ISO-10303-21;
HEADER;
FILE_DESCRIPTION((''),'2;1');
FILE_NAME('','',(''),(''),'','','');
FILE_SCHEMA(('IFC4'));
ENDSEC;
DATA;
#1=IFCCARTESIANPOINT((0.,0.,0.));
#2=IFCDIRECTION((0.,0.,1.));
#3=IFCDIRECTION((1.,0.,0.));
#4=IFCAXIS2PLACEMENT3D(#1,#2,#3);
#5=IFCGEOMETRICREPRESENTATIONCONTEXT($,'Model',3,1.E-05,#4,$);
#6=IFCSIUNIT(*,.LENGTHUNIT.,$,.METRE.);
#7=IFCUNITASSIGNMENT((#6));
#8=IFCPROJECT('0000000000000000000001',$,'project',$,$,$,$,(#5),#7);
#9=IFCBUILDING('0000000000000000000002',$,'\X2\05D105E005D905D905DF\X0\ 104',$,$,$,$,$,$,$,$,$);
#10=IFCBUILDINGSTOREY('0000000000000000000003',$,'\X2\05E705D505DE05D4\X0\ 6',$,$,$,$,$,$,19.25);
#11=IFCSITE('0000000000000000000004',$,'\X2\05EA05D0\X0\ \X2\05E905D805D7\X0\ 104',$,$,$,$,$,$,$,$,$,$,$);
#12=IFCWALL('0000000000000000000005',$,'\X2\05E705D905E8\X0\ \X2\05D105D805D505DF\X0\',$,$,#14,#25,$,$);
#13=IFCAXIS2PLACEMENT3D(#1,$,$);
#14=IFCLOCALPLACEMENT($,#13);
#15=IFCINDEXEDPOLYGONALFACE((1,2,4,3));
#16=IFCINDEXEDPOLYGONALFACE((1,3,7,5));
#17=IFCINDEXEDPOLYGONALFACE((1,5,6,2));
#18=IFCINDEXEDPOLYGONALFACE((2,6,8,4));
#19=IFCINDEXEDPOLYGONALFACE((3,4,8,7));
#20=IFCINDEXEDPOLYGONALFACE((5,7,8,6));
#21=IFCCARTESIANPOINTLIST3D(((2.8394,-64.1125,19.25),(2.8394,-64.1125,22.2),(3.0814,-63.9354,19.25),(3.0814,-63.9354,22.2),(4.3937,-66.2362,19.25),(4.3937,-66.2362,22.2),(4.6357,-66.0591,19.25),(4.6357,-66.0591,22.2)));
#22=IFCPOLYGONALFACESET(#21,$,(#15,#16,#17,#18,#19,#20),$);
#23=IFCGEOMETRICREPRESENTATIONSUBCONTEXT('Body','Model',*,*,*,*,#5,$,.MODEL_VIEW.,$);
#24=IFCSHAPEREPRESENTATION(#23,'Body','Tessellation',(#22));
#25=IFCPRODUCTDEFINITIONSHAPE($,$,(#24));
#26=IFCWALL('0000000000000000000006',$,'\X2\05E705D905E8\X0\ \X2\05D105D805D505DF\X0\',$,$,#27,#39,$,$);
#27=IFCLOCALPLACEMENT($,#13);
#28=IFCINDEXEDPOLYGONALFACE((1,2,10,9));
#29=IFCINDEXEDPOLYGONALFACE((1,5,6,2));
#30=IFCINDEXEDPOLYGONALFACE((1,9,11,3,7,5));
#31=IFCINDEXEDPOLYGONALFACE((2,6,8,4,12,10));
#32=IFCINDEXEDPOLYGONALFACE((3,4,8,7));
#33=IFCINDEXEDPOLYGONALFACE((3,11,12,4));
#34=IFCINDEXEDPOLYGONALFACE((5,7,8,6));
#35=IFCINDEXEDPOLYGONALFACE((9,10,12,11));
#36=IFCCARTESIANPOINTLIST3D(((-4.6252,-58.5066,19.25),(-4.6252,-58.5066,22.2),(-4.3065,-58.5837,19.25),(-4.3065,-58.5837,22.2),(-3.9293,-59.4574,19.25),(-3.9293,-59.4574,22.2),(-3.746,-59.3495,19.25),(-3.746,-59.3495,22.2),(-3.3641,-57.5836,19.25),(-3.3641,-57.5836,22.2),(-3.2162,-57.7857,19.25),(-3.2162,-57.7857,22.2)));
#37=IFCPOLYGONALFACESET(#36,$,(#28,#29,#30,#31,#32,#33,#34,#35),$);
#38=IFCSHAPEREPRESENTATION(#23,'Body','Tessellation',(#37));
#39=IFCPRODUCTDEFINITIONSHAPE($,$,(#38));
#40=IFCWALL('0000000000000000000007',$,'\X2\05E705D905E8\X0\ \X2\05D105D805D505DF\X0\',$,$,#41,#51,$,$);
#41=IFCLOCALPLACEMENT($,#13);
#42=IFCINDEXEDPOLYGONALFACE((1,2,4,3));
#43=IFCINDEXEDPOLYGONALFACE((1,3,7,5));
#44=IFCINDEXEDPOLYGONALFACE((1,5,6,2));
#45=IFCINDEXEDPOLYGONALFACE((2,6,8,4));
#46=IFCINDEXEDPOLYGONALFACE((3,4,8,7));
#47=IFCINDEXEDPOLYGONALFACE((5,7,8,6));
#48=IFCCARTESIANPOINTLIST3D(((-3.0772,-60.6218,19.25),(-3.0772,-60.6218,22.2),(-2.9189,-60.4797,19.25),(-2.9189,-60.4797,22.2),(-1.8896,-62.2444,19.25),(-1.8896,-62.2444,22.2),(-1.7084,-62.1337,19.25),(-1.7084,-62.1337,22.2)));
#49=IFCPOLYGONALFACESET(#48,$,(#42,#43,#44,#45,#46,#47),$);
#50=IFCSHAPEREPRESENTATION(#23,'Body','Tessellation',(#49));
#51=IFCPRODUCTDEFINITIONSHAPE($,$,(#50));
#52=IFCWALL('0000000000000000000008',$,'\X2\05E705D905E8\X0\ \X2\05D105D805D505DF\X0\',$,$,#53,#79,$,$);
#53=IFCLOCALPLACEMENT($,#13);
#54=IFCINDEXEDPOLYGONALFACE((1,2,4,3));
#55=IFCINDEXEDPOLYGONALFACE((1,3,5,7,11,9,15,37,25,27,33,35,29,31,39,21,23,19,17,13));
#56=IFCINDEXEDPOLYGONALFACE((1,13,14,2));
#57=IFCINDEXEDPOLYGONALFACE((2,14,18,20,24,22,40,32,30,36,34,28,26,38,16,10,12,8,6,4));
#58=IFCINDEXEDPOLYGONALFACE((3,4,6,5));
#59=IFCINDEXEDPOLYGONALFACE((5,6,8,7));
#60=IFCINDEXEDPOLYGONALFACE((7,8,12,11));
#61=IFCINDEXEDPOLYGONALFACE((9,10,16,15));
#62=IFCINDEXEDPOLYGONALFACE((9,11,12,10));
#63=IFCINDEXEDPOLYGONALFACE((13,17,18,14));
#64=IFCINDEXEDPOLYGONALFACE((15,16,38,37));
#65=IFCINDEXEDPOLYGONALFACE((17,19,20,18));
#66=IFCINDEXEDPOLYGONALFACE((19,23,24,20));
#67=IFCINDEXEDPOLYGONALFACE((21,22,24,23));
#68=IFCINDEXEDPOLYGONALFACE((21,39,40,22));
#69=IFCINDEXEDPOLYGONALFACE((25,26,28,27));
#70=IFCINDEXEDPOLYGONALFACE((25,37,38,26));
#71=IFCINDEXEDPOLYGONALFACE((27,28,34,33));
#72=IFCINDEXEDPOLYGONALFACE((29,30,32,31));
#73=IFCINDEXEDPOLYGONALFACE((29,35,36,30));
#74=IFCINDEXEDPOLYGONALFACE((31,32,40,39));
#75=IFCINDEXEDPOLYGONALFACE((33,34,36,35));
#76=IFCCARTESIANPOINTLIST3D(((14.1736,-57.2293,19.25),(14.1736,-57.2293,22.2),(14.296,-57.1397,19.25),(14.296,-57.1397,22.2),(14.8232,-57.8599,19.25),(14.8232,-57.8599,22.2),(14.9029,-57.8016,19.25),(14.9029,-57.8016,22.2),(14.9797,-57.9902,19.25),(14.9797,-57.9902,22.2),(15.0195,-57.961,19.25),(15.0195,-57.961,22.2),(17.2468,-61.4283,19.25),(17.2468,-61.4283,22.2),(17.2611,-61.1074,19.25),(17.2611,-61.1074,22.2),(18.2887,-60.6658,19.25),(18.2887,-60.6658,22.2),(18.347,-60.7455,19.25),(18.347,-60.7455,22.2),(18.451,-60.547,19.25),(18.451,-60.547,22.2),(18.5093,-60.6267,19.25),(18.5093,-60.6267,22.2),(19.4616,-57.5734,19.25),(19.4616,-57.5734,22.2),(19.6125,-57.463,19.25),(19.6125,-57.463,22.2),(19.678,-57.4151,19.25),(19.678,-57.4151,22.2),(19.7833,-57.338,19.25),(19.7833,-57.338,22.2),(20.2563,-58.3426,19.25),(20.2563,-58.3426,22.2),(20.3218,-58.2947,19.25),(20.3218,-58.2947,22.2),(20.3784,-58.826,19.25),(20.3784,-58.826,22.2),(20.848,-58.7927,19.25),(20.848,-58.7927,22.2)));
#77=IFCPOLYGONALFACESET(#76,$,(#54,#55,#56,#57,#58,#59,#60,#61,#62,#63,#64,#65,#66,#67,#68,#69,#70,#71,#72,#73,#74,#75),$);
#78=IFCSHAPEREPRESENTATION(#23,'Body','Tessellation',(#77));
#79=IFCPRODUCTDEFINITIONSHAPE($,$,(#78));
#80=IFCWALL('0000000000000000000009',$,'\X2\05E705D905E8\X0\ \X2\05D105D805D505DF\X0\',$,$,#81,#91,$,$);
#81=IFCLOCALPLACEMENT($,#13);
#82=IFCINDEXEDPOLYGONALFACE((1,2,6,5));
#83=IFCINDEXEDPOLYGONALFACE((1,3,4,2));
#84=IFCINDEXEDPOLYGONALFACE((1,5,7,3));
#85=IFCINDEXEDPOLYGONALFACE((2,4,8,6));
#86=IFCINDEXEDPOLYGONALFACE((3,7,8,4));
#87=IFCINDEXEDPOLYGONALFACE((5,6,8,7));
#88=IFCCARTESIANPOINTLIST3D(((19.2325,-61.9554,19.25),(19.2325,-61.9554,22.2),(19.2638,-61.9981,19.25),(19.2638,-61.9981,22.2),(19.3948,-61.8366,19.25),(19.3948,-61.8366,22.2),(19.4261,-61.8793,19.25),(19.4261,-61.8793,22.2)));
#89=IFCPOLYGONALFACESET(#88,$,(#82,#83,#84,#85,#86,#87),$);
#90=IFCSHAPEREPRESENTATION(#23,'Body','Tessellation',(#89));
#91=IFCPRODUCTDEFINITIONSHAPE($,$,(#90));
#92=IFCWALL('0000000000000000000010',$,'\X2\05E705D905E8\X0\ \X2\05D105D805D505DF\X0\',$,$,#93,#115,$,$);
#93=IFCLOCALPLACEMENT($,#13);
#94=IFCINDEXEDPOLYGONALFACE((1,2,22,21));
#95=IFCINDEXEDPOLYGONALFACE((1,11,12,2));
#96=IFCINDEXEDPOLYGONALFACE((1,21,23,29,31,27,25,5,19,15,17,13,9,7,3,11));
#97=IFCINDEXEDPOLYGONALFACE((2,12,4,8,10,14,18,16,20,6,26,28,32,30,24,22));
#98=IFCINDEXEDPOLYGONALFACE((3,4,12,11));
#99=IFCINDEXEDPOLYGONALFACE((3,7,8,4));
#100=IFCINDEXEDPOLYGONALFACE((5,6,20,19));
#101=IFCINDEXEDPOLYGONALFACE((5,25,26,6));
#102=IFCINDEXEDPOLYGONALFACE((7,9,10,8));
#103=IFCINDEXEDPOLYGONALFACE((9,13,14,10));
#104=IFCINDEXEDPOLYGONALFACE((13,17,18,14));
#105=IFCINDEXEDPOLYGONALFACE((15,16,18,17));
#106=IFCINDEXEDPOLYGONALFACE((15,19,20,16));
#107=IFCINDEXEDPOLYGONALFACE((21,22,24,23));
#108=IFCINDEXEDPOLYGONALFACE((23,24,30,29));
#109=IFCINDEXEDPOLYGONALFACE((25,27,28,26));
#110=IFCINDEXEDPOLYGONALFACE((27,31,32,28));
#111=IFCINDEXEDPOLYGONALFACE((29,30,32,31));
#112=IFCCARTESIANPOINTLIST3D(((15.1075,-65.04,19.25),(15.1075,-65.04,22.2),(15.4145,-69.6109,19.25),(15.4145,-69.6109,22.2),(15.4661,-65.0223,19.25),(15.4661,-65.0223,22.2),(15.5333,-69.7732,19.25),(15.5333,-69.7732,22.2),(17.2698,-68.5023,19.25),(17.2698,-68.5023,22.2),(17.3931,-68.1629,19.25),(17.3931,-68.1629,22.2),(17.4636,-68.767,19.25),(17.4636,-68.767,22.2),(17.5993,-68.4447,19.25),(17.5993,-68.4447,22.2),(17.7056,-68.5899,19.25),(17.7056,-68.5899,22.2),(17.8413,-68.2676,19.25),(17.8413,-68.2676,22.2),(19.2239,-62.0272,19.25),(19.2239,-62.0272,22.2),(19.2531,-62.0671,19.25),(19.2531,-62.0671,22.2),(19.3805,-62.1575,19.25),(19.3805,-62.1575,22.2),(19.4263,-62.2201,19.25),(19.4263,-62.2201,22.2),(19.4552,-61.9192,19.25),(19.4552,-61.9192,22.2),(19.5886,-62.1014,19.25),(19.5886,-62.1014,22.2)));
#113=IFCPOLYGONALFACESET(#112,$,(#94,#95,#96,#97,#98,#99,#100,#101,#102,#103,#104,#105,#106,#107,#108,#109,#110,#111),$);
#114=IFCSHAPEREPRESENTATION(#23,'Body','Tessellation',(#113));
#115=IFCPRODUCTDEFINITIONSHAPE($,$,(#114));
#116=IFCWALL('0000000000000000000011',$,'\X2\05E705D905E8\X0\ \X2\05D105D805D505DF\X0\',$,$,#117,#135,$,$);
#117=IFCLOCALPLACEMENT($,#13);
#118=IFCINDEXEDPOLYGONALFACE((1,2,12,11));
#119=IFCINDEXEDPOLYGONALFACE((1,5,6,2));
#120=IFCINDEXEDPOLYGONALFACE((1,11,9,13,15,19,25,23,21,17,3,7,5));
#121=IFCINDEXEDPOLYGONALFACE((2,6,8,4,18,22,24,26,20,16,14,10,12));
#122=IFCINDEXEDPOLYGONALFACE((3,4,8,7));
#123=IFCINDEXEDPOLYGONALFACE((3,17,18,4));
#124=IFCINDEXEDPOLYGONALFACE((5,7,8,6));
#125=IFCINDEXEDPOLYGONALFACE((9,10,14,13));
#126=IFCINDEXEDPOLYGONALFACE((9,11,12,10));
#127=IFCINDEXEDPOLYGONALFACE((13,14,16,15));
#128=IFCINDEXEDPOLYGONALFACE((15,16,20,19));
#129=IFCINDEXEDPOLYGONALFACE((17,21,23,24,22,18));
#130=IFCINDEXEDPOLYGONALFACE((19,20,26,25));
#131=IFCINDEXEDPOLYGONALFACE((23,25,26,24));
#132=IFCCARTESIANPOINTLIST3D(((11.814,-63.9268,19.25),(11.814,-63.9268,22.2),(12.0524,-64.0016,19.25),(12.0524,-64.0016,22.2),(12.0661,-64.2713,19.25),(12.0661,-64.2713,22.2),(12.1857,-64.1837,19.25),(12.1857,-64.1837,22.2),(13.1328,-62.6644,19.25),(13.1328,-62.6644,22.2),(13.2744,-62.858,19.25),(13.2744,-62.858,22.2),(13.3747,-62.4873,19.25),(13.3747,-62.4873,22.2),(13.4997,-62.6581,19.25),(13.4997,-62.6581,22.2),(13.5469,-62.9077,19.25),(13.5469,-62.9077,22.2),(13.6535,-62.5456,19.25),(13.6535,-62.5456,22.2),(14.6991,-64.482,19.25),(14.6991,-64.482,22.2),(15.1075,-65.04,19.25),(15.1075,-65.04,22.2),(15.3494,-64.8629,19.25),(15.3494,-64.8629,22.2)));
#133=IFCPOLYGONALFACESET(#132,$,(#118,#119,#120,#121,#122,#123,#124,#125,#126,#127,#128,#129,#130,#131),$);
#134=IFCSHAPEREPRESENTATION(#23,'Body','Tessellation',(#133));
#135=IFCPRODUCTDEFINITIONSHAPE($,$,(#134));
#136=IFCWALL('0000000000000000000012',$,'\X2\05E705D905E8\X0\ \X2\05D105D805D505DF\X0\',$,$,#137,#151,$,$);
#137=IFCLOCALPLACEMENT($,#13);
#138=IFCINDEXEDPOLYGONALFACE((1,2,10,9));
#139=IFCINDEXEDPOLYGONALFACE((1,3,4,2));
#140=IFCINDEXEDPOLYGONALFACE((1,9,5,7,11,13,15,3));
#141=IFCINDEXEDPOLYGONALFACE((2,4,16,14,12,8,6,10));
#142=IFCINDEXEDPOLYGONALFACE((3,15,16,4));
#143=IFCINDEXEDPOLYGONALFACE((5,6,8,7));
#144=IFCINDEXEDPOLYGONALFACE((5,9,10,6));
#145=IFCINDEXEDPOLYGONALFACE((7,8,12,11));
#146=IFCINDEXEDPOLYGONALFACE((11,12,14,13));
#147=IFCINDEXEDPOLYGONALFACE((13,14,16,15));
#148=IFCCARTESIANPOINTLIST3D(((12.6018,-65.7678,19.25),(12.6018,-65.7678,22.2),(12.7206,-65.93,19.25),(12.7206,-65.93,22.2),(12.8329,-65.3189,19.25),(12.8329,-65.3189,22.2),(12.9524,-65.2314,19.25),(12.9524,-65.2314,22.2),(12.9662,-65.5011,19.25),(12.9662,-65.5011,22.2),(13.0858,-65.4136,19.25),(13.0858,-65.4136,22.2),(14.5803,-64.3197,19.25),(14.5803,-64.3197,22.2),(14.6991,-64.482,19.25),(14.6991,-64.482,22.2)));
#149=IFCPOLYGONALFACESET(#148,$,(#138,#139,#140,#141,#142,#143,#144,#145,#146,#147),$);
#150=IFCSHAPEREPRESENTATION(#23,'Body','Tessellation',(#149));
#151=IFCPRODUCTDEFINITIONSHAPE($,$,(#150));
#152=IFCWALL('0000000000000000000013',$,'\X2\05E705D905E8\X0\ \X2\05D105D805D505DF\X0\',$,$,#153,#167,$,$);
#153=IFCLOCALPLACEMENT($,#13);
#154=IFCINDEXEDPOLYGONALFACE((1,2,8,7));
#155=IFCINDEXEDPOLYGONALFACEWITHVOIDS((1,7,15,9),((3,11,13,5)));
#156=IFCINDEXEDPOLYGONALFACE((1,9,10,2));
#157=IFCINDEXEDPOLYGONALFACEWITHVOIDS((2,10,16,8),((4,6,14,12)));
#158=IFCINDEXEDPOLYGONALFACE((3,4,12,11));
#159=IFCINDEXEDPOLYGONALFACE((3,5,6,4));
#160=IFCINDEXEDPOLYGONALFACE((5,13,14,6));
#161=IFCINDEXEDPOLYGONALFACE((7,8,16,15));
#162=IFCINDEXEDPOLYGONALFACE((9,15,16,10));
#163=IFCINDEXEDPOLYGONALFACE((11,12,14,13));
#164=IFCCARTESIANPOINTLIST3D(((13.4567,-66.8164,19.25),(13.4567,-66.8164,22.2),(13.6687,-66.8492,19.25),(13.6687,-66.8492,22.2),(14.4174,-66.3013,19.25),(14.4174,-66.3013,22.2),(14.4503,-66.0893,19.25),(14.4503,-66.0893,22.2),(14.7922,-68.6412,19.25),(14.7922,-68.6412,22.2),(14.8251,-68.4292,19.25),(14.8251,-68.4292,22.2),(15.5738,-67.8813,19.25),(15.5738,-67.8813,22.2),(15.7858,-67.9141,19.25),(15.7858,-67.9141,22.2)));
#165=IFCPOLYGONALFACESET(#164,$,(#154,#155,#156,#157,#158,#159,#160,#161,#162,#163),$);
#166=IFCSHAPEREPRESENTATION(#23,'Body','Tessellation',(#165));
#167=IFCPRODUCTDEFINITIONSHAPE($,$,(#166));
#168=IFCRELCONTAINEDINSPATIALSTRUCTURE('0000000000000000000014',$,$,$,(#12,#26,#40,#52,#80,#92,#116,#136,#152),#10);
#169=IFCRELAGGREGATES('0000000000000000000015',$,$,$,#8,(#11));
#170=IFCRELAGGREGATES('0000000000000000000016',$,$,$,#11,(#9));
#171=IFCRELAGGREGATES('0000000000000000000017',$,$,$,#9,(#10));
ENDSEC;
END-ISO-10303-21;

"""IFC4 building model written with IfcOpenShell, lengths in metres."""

from ifc_helpers import new_model, si_unit, frame, origin_with_axes, context, subcontext, project, spatial, polyline, outline, extrude, element, save


model = new_model("IFC4")

# Units and contexts
model_context = context("Model", 3, precision=1e-05, world=origin_with_axes())
body_context = subcontext(model_context, "Body", "Model", "MODEL_VIEW")
ifc_project = project(units=[si_unit("LENGTHUNIT", "METRE")], contexts=[model_context])

# Site, building, storey
site = spatial("IfcSite", under=ifc_project, Name="תא שטח 104")
building = spatial("IfcBuilding", under=site, Name="בניין 104")
storey = spatial("IfcBuildingStorey", under=building, Name="קומה 6", Elevation=19.25)

# Walls
element("IfcWall", 1, inside=storey, Name="קיר בטון", context=body_context, shape_type="SweptSolid", body=[
    extrude(outline(polyline([(4.6357, -66.0591), (3.0814, -63.9354), (2.8394, -64.1125), (4.3937, -66.2362), (4.6357, -66.0591)])), frame((0.0, 0.0, 19.25)), (0.0, 0.0, 1.0), 2.95),
])
element("IfcWall", 2, inside=storey, Name="קיר בטון", context=body_context, shape_type="SweptSolid", body=[
    extrude(outline(polyline([(-4.6252, -58.5066), (-3.9293, -59.4574), (-3.746, -59.3495), (-4.3065, -58.5837), (-3.2162, -57.7857), (-3.3641, -57.5836), (-4.6252, -58.5066)])), frame((0.0, 0.0, 19.25)), (0.0, 0.0, 1.0), 2.95),
])
element("IfcWall", 3, inside=storey, Name="קיר בטון", context=body_context, shape_type="SweptSolid", body=[
    extrude(outline(polyline([(-3.0772, -60.6218), (-1.8896, -62.2444), (-1.7084, -62.1337), (-2.9189, -60.4797), (-3.0772, -60.6218)])), frame((0.0, 0.0, 19.25)), (0.0, 0.0, 1.0), 2.95),
])
element("IfcWall", 4, inside=storey, Name="קיר בטון", context=body_context, shape_type="SweptSolid", body=[
    extrude(outline(polyline([(19.6125, -57.463), (19.4616, -57.5734), (20.3784, -58.826), (17.2611, -61.1074), (14.9797, -57.9902), (15.0195, -57.961), (14.9029, -57.8016), (14.8232, -57.8599), (14.296, -57.1397), (14.1736, -57.2293), (17.2468, -61.4283), (18.2887, -60.6658), (18.347, -60.7455), (18.5093, -60.6267), (18.451, -60.547), (20.848, -58.7927), (19.7833, -57.338), (19.678, -57.4151), (20.3218, -58.2947), (20.2563, -58.3426), (19.6125, -57.463)])), frame((0.0, 0.0, 19.25)), (0.0, 0.0, 1.0), 2.95),
])
element("IfcWall", 5, inside=storey, Name="קיר בטון", context=body_context, shape_type="SweptSolid", body=[
    extrude(outline(polyline([(19.4261, -61.8793), (19.3948, -61.8366), (19.2325, -61.9554), (19.2638, -61.9981), (19.4261, -61.8793)])), frame((0.0, 0.0, 19.25)), (0.0, 0.0, 1.0), 2.95),
])
element("IfcWall", 6, inside=storey, Name="קיר בטון", context=body_context, shape_type="SweptSolid", body=[
    extrude(outline(polyline([(19.4552, -61.9192), (19.2531, -62.0671), (19.2239, -62.0272), (15.1075, -65.04), (15.1075, -65.04), (17.3931, -68.1629), (15.4145, -69.6109), (15.5333, -69.7732), (17.2698, -68.5023), (17.4636, -68.767), (17.7056, -68.5899), (17.5993, -68.4447), (17.8413, -68.2676), (15.4661, -65.0223), (19.3805, -62.1575), (19.4263, -62.2201), (19.5886, -62.1014), (19.4552, -61.9192)])), frame((0.0, 0.0, 19.25)), (0.0, 0.0, 1.0), 2.95),
])
element("IfcWall", 7, inside=storey, Name="קיר בטון", context=body_context, shape_type="SweptSolid", body=[
    extrude(outline(polyline([(13.1328, -62.6644), (13.2744, -62.858), (11.814, -63.9268), (12.0661, -64.2713), (12.1857, -64.1837), (12.0524, -64.0016), (13.5469, -62.9077), (14.6991, -64.482), (15.1075, -65.04), (15.3494, -64.8629), (13.6535, -62.5456), (13.4997, -62.6581), (13.3747, -62.4873), (13.1328, -62.6644)])), frame((0.0, 0.0, 19.25)), (0.0, 0.0, 1.0), 2.95),
])
element("IfcWall", 8, inside=storey, Name="קיר בטון", context=body_context, shape_type="SweptSolid", body=[
    extrude(outline(polyline([(12.9662, -65.5011), (12.6018, -65.7678), (12.7206, -65.93), (14.6991, -64.482), (14.5803, -64.3197), (13.0858, -65.4136), (12.9524, -65.2314), (12.8329, -65.3189), (12.9662, -65.5011)])), frame((0.0, 0.0, 19.25)), (0.0, 0.0, 1.0), 2.95),
])
element("IfcWall", 9, inside=storey, Name="קיר בטון", context=body_context, shape_type="SweptSolid", body=[
    extrude(outline(polyline([(14.4503, -66.0893), (13.4567, -66.8164), (14.7922, -68.6412), (15.7858, -67.9141), (14.4503, -66.0893)]), holes=[polyline([(13.6687, -66.8492), (14.4174, -66.3013), (15.5738, -67.8813), (14.8251, -68.4292), (13.6687, -66.8492)])]), frame((0.0, 0.0, 19.25)), (0.0, 0.0, 1.0), 2.95),
])

save(model, "model.ifc")
